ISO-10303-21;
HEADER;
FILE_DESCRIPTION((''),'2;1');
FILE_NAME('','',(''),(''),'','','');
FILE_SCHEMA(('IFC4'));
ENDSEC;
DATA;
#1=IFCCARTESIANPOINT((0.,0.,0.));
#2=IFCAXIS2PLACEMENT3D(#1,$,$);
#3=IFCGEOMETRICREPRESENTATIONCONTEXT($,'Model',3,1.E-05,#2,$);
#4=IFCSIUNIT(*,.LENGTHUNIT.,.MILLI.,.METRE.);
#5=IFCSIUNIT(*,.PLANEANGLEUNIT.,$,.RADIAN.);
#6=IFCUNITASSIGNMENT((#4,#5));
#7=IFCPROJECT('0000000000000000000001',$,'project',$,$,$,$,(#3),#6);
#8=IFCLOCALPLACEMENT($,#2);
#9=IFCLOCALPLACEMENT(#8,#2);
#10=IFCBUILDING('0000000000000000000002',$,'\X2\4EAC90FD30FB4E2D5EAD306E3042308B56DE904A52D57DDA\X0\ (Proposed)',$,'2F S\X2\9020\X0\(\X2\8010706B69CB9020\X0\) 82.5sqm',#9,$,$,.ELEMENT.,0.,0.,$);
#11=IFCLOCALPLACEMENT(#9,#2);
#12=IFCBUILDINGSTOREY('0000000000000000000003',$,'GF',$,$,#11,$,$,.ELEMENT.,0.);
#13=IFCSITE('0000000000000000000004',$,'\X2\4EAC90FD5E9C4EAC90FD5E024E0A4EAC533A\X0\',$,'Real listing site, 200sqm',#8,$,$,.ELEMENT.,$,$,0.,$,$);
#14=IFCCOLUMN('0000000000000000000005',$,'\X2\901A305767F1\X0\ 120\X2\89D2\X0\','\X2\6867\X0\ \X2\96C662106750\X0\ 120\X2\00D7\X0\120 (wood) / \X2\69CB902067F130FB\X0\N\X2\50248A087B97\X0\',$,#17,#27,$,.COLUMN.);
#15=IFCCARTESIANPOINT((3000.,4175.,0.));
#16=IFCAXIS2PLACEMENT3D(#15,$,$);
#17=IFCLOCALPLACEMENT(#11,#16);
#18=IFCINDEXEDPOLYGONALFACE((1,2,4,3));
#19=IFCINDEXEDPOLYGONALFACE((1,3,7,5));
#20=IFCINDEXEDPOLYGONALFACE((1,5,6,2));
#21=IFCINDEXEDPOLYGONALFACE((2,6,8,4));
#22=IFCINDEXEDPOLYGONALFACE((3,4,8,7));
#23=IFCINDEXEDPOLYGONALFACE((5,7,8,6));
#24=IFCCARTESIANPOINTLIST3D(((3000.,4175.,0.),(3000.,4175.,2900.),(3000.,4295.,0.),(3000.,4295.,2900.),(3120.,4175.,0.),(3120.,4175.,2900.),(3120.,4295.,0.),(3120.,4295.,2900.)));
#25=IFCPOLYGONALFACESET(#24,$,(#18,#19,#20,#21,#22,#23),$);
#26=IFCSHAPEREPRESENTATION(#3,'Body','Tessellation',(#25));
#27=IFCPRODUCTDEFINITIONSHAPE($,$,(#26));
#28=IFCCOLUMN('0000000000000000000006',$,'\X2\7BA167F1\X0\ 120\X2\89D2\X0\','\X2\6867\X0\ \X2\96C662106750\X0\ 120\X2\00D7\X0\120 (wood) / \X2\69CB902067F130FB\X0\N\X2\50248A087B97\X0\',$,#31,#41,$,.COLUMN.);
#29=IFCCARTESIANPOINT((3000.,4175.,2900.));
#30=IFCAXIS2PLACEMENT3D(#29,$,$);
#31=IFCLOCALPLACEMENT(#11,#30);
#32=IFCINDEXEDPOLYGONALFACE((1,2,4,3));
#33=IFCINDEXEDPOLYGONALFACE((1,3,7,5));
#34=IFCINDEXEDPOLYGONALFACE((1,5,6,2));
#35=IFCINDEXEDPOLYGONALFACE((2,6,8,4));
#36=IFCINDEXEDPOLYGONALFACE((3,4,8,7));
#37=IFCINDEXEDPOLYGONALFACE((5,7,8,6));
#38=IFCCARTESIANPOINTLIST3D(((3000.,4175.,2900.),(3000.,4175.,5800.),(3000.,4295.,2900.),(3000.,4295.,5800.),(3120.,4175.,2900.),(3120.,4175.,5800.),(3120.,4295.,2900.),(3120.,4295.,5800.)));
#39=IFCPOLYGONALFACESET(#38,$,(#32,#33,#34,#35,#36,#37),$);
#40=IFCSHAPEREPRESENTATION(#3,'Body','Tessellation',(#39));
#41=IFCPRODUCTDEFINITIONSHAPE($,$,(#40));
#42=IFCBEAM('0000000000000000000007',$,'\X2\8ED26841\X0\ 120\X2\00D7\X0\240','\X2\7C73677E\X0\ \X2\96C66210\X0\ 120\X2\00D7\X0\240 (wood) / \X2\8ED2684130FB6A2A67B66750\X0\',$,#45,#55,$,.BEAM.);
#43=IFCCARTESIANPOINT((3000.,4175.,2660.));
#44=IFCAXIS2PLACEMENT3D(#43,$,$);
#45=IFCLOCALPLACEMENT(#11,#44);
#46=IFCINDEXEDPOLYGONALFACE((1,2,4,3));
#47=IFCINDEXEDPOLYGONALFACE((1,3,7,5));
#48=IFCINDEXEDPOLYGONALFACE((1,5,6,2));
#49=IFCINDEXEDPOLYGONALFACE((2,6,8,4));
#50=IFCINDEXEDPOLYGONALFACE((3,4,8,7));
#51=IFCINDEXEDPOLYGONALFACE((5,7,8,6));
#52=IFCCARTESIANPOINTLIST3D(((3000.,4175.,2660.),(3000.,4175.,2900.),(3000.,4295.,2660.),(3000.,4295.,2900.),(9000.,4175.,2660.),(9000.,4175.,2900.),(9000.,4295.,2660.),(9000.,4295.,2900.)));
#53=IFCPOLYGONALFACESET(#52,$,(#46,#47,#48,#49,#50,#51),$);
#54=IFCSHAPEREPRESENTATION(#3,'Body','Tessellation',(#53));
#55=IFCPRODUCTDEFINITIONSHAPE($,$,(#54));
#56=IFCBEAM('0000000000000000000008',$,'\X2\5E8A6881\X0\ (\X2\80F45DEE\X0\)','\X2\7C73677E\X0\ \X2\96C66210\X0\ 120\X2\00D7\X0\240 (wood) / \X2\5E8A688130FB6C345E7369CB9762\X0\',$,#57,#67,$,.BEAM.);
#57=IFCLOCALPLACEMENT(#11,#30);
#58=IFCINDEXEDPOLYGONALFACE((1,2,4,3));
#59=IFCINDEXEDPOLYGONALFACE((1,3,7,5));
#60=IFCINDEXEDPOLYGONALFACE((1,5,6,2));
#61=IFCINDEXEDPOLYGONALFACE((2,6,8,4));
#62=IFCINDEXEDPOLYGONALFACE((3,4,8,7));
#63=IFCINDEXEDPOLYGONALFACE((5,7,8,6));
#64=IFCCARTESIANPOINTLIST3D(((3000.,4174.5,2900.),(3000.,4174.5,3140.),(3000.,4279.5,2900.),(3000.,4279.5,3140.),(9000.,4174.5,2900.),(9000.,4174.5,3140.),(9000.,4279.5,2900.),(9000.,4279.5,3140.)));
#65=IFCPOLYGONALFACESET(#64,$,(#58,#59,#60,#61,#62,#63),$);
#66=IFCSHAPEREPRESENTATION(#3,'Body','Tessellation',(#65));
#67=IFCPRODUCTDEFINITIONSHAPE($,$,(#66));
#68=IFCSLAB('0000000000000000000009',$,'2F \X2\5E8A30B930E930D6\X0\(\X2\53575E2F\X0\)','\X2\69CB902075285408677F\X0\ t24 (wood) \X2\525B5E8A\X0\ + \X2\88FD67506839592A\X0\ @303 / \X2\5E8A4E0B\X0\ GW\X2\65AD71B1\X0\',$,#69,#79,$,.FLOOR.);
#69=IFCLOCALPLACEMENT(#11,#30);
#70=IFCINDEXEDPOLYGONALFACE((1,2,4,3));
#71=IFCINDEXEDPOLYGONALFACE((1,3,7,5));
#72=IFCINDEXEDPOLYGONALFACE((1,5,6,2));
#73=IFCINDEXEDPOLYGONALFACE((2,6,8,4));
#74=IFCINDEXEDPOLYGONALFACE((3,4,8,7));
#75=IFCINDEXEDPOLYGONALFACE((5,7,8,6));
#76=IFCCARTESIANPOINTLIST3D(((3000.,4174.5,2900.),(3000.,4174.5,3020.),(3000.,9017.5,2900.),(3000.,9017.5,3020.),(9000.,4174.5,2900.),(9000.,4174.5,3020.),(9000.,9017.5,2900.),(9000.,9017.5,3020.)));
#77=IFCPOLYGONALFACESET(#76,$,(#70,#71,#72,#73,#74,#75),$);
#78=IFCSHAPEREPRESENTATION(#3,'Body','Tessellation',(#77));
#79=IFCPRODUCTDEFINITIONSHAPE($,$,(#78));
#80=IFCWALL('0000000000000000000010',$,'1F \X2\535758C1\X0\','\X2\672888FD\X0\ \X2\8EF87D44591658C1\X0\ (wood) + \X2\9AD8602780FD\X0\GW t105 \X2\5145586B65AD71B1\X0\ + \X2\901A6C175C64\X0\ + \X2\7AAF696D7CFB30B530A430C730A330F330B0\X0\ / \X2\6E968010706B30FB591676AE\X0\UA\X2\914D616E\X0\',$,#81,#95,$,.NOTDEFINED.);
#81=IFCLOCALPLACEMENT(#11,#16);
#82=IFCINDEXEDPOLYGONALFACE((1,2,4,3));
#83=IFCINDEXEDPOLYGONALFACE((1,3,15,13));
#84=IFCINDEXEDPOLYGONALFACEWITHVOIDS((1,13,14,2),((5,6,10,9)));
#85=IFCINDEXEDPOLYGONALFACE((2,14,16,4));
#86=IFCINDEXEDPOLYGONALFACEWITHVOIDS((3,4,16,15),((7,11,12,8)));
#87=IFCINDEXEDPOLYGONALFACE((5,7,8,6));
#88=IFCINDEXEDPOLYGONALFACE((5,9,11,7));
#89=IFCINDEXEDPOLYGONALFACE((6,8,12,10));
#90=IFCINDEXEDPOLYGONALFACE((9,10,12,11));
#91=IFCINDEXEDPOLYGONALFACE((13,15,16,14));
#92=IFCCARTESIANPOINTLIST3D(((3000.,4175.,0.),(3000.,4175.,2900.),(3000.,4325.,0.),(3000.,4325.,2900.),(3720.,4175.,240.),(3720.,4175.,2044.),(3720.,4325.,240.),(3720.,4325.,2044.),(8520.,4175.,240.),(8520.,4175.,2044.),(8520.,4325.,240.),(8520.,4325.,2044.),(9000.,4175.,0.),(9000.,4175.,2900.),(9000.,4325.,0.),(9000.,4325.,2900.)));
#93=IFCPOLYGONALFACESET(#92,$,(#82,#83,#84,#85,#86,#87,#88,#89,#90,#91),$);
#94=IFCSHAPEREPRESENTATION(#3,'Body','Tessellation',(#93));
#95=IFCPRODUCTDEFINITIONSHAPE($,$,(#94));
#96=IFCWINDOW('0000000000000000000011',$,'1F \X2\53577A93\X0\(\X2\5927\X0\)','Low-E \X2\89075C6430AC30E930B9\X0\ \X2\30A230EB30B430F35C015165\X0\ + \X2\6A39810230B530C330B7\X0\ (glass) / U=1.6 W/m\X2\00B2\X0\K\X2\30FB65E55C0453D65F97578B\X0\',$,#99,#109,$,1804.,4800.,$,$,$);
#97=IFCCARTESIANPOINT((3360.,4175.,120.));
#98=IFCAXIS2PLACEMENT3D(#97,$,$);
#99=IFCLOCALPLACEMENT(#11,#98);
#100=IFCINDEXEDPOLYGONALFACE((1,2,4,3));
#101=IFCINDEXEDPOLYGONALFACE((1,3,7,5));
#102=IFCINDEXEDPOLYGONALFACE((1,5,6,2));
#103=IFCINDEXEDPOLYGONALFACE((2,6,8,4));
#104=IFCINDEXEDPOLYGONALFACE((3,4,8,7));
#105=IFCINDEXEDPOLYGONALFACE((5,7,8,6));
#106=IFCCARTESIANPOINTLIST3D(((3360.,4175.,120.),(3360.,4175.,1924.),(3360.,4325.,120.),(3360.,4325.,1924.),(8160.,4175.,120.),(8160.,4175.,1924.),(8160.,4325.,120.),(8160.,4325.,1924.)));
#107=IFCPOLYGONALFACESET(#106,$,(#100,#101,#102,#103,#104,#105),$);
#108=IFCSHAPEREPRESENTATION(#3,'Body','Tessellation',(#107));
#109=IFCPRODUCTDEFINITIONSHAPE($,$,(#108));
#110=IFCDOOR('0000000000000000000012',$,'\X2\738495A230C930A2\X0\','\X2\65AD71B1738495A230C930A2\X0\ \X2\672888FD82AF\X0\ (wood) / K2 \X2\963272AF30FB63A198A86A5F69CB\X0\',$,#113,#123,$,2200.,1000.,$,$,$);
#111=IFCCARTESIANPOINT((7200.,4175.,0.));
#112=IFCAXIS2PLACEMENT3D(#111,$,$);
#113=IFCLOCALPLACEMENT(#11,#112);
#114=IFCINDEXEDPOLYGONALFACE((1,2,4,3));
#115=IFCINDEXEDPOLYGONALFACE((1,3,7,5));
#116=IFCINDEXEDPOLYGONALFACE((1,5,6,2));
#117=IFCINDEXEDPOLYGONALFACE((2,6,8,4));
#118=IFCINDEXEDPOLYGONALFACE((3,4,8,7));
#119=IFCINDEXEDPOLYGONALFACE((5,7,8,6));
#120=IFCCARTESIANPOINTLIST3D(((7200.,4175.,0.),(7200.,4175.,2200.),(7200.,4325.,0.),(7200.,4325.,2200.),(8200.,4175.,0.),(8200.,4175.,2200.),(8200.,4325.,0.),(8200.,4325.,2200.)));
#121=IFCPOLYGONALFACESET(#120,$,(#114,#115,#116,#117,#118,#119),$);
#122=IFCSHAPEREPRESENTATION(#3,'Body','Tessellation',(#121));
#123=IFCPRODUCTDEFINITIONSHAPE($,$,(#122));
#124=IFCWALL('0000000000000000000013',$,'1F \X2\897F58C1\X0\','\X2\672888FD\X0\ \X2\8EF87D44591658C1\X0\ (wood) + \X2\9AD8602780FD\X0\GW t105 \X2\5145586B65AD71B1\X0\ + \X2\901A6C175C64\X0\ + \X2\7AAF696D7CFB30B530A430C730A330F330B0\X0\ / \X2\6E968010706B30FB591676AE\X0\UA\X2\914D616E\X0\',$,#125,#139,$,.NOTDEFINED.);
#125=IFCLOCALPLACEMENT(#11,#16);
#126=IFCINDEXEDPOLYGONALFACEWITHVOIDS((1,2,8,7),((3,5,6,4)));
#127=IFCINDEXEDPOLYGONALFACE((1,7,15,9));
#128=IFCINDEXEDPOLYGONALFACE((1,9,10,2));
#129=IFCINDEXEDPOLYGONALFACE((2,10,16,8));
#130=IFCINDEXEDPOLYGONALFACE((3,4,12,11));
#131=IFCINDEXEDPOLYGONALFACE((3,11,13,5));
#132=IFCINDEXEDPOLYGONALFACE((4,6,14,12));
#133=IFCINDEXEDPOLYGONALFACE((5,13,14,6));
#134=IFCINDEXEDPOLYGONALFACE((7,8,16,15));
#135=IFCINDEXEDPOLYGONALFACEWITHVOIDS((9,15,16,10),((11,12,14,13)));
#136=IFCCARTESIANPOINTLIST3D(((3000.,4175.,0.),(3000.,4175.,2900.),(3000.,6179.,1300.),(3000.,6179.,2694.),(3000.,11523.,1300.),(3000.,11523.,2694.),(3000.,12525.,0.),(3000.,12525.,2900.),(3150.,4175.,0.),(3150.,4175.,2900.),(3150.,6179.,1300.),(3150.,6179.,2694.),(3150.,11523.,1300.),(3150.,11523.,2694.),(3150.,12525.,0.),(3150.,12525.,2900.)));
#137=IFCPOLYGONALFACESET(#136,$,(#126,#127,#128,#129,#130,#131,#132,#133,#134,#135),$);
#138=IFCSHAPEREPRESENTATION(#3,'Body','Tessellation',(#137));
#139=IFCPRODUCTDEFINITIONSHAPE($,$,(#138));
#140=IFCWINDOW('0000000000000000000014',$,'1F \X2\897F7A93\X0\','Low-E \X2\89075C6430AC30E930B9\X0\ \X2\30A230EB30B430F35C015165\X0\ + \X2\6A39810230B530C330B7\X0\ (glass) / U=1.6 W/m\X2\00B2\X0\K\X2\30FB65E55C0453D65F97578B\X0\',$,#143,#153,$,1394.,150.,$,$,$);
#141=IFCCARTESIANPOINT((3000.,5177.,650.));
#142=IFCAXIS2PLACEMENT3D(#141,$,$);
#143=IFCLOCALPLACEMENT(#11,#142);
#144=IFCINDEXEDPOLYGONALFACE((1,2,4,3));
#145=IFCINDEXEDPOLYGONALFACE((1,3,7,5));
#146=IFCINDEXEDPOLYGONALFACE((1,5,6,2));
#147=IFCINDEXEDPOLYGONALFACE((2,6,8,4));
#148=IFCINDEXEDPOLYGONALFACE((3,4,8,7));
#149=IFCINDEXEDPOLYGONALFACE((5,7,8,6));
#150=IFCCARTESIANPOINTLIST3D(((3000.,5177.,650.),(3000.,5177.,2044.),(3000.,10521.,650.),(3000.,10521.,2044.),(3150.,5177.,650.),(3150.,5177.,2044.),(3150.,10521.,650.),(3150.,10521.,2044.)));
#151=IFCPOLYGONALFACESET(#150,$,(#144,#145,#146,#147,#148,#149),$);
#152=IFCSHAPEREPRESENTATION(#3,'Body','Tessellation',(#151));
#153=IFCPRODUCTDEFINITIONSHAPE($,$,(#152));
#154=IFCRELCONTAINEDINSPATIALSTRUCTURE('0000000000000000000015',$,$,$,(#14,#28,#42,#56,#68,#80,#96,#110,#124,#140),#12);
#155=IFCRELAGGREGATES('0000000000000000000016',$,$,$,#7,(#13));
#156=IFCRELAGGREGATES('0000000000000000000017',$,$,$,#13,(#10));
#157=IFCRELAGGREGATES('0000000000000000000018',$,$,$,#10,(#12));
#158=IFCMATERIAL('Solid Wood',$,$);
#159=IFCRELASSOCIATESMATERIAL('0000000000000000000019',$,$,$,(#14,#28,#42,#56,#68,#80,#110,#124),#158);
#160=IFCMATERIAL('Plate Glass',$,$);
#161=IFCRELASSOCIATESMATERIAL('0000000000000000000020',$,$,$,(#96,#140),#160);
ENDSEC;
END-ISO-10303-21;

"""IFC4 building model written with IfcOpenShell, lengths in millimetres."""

from ifc_helpers import new_model, si_unit, frame, frame_2d, origin, place, context, project, spatial, rectangle, extrude, material, element, fill, save


model = new_model("IFC4")

# Units and contexts
model_context = context("Model", 3, precision=1e-05, world=origin())
ifc_project = project(units=[si_unit("LENGTHUNIT", "METRE", prefix="MILLI"), si_unit("PLANEANGLEUNIT", "RADIAN")], contexts=[model_context])

# Site, building, storey
site_placement = place(None, origin())
site = spatial("IfcSite", under=ifc_project, at=site_placement, Name="京都府京都市上京区", ObjectType="Real listing site, 200sqm", CompositionType="ELEMENT", RefElevation=0.0)
building_placement = place(site_placement, origin())
building = spatial("IfcBuilding", under=site, at=building_placement, Name="京都・中庭のある回遊動線 (Proposed)", ObjectType="2F S造(耐火構造) 82.5sqm", CompositionType="ELEMENT", ElevationOfRefHeight=0.0, ElevationOfTerrain=0.0)
storey_placement = place(building_placement, origin())
storey = spatial("IfcBuildingStorey", under=building, at=storey_placement, Name="GF", CompositionType="ELEMENT", Elevation=0.0)

# Columns
ifc_material_1 = material(Name="Solid Wood")
column_1_placement = place(storey_placement, frame((3000.0, 4175.0, 0.0)))
element("IfcColumn", 1, at=column_1_placement, inside=storey, material=ifc_material_1, Name="通し柱 120角", Description="桧 集成材 120×120 (wood) / 構造柱・N値計算", PredefinedType="COLUMN", context=model_context, shape_type="SweptSolid", body=[
    extrude(rectangle(XDim=120.0, YDim=120.0, at=frame_2d((60.0, 60.0))), frame((3000.0, 4175.0, 0.0)), (0.0, 0.0, 1.0), 2900.0),
])
column_2_placement = place(storey_placement, frame((3000.0, 4175.0, 2900.0)))
element("IfcColumn", 2, at=column_2_placement, inside=storey, material=ifc_material_1, Name="管柱 120角", Description="桧 集成材 120×120 (wood) / 構造柱・N値計算", PredefinedType="COLUMN", context=model_context, shape_type="SweptSolid", body=[
    extrude(rectangle(XDim=120.0, YDim=120.0, at=frame_2d((60.0, 60.0))), frame((3000.0, 4175.0, 2900.0)), (0.0, 0.0, 1.0), 2900.0),
])

# Beams
beam_1_placement = place(storey_placement, frame((3000.0, 4175.0, 2660.0)))
element("IfcBeam", 3, at=beam_1_placement, inside=storey, material=ifc_material_1, Name="軒桁 120×240", Description="米松 集成 120×240 (wood) / 軒桁・横架材", PredefinedType="BEAM", context=model_context, shape_type="SweptSolid", body=[
    extrude(rectangle(XDim=6000.0, YDim=120.0, at=frame_2d((3000.0, 60.0))), frame((3000.0, 4175.0, 2660.0)), (0.0, 0.0, 1.0), 240.0),
])
beam_2_placement = place(storey_placement, frame((3000.0, 4175.0, 2900.0)))
element("IfcBeam", 4, at=beam_2_placement, inside=storey, material=ifc_material_1, Name="床梁 (胴差)", Description="米松 集成 120×240 (wood) / 床梁・水平構面", PredefinedType="BEAM", context=model_context, shape_type="SweptSolid", body=[
    extrude(rectangle(XDim=6000.0, YDim=105.0, at=frame_2d((3000.0, 52.0))), frame((3000.0, 4175.0, 2900.0)), (0.0, 0.0, 1.0), 240.0),
])

# Slab
slab_1_placement = place(storey_placement, frame((3000.0, 4175.0, 2900.0)))
element("IfcSlab", 5, at=slab_1_placement, inside=storey, material=ifc_material_1, Name="2F 床スラブ(南帯)", Description="構造用合板 t24 (wood) 剛床 + 製材根太 @303 / 床下 GW断熱", PredefinedType="FLOOR", context=model_context, shape_type="SweptSolid", body=[
    extrude(rectangle(XDim=6000.0, YDim=4843.0, at=frame_2d((3000.0, 2421.0))), frame((3000.0, 4175.0, 2900.0)), (0.0, 0.0, 1.0), 120.0),
])

# Wall, openings, window, door
wall_1_placement = place(storey_placement, frame((3000.0, 4175.0, 0.0)))
wall_1 = element("IfcWall", 6, at=wall_1_placement, inside=storey, material=ifc_material_1, Name="1F 南壁", Description="木製 軸組外壁 (wood) + 高性能GW t105 充填断熱 + 通気層 + 窯業系サイディング / 準耐火・外皮UA配慮", PredefinedType="NOTDEFINED", context=model_context, shape_type="SweptSolid", body=[
    extrude(rectangle(XDim=6000.0, YDim=150.0, at=frame_2d((3000.0, 75.0))), frame((3000.0, 4175.0, 0.0)), (0.0, 0.0, 1.0), 2900.0),
])
opening_1_placement = place(storey_placement, frame((3360.0, 4175.0, 120.0)))
opening_1 = element("IfcOpeningElement", 7, at=opening_1_placement, cuts=wall_1, PredefinedType="NOTDEFINED", context=model_context, shape_type="SweptSolid", body=[
    extrude(rectangle(XDim=4800.0, YDim=150.0, at=frame_2d((2400.0, 75.0))), frame((3360.0, 4175.0, 120.0)), (0.0, 0.0, 1.0), 1804.0),
])
opening_2_placement = place(storey_placement, frame((7200.0, 4175.0, 0.0)))
opening_2 = element("IfcOpeningElement", 8, at=opening_2_placement, cuts=wall_1, PredefinedType="NOTDEFINED", context=model_context, shape_type="SweptSolid", body=[
    extrude(rectangle(XDim=1000.0, YDim=150.0, at=frame_2d((500.0, 75.0))), frame((7200.0, 4175.0, 0.0)), (0.0, 0.0, 1.0), 2200.0),
])
ifc_material_2 = material(Name="Plate Glass")
window_1_placement = place(storey_placement, frame((3360.0, 4175.0, 120.0)))
window_1 = element("IfcWindow", 9, at=window_1_placement, inside=storey, material=ifc_material_2, Name="1F 南窓(大)", Description="Low-E 複層ガラス アルゴン封入 + 樹脂サッシ (glass) / U=1.6 W/m²K・日射取得型", OverallHeight=1804.0, OverallWidth=4800.0, context=model_context, shape_type="SweptSolid", body=[
    extrude(rectangle(XDim=4800.0, YDim=150.0, at=frame_2d((2400.0, 75.0))), frame((3360.0, 4175.0, 120.0)), (0.0, 0.0, 1.0), 1804.0),
])
fill(opening_1, window_1)
door_placement = place(storey_placement, frame((7200.0, 4175.0, 0.0)))
door = element("IfcDoor", 10, at=door_placement, inside=storey, material=ifc_material_1, Name="玄関ドア", Description="断熱玄関ドア 木製芯 (wood) / K2 防犯・採風機構", OverallHeight=2200.0, OverallWidth=1000.0, context=model_context, shape_type="SweptSolid", body=[
    extrude(rectangle(XDim=1000.0, YDim=150.0, at=frame_2d((500.0, 75.0))), frame((7200.0, 4175.0, 0.0)), (0.0, 0.0, 1.0), 2200.0),
])
fill(opening_2, door)

# Wall, opening, window
wall_2_placement = place(storey_placement, frame((3000.0, 4175.0, 0.0)))
wall_2 = element("IfcWall", 11, at=wall_2_placement, inside=storey, material=ifc_material_1, Name="1F 西壁", Description="木製 軸組外壁 (wood) + 高性能GW t105 充填断熱 + 通気層 + 窯業系サイディング / 準耐火・外皮UA配慮", PredefinedType="NOTDEFINED", context=model_context, shape_type="SweptSolid", body=[
    extrude(rectangle(XDim=150.0, YDim=8350.0, at=frame_2d((75.0, 4175.0))), frame((3000.0, 4175.0, 0.0)), (0.0, 0.0, 1.0), 2900.0),
])
opening_3_placement = place(storey_placement, frame((3000.0, 5177.0, 650.0)))
opening_3 = element("IfcOpeningElement", 12, at=opening_3_placement, cuts=wall_2, PredefinedType="NOTDEFINED", context=model_context, shape_type="SweptSolid", body=[
    extrude(rectangle(XDim=150.0, YDim=5344.0, at=frame_2d((75.0, 2672.0))), frame((3000.0, 5177.0, 650.0)), (0.0, 0.0, 1.0), 1394.0),
])
window_2_placement = place(storey_placement, frame((3000.0, 5177.0, 650.0)))
window_2 = element("IfcWindow", 13, at=window_2_placement, inside=storey, material=ifc_material_2, Name="1F 西窓", Description="Low-E 複層ガラス アルゴン封入 + 樹脂サッシ (glass) / U=1.6 W/m²K・日射取得型", OverallHeight=1394.0, OverallWidth=150.0, context=model_context, shape_type="SweptSolid", body=[
    extrude(rectangle(XDim=150.0, YDim=5344.0, at=frame_2d((75.0, 2672.0))), frame((3000.0, 5177.0, 650.0)), (0.0, 0.0, 1.0), 1394.0),
])
fill(opening_3, window_2)

save(model, "model.ifc")
